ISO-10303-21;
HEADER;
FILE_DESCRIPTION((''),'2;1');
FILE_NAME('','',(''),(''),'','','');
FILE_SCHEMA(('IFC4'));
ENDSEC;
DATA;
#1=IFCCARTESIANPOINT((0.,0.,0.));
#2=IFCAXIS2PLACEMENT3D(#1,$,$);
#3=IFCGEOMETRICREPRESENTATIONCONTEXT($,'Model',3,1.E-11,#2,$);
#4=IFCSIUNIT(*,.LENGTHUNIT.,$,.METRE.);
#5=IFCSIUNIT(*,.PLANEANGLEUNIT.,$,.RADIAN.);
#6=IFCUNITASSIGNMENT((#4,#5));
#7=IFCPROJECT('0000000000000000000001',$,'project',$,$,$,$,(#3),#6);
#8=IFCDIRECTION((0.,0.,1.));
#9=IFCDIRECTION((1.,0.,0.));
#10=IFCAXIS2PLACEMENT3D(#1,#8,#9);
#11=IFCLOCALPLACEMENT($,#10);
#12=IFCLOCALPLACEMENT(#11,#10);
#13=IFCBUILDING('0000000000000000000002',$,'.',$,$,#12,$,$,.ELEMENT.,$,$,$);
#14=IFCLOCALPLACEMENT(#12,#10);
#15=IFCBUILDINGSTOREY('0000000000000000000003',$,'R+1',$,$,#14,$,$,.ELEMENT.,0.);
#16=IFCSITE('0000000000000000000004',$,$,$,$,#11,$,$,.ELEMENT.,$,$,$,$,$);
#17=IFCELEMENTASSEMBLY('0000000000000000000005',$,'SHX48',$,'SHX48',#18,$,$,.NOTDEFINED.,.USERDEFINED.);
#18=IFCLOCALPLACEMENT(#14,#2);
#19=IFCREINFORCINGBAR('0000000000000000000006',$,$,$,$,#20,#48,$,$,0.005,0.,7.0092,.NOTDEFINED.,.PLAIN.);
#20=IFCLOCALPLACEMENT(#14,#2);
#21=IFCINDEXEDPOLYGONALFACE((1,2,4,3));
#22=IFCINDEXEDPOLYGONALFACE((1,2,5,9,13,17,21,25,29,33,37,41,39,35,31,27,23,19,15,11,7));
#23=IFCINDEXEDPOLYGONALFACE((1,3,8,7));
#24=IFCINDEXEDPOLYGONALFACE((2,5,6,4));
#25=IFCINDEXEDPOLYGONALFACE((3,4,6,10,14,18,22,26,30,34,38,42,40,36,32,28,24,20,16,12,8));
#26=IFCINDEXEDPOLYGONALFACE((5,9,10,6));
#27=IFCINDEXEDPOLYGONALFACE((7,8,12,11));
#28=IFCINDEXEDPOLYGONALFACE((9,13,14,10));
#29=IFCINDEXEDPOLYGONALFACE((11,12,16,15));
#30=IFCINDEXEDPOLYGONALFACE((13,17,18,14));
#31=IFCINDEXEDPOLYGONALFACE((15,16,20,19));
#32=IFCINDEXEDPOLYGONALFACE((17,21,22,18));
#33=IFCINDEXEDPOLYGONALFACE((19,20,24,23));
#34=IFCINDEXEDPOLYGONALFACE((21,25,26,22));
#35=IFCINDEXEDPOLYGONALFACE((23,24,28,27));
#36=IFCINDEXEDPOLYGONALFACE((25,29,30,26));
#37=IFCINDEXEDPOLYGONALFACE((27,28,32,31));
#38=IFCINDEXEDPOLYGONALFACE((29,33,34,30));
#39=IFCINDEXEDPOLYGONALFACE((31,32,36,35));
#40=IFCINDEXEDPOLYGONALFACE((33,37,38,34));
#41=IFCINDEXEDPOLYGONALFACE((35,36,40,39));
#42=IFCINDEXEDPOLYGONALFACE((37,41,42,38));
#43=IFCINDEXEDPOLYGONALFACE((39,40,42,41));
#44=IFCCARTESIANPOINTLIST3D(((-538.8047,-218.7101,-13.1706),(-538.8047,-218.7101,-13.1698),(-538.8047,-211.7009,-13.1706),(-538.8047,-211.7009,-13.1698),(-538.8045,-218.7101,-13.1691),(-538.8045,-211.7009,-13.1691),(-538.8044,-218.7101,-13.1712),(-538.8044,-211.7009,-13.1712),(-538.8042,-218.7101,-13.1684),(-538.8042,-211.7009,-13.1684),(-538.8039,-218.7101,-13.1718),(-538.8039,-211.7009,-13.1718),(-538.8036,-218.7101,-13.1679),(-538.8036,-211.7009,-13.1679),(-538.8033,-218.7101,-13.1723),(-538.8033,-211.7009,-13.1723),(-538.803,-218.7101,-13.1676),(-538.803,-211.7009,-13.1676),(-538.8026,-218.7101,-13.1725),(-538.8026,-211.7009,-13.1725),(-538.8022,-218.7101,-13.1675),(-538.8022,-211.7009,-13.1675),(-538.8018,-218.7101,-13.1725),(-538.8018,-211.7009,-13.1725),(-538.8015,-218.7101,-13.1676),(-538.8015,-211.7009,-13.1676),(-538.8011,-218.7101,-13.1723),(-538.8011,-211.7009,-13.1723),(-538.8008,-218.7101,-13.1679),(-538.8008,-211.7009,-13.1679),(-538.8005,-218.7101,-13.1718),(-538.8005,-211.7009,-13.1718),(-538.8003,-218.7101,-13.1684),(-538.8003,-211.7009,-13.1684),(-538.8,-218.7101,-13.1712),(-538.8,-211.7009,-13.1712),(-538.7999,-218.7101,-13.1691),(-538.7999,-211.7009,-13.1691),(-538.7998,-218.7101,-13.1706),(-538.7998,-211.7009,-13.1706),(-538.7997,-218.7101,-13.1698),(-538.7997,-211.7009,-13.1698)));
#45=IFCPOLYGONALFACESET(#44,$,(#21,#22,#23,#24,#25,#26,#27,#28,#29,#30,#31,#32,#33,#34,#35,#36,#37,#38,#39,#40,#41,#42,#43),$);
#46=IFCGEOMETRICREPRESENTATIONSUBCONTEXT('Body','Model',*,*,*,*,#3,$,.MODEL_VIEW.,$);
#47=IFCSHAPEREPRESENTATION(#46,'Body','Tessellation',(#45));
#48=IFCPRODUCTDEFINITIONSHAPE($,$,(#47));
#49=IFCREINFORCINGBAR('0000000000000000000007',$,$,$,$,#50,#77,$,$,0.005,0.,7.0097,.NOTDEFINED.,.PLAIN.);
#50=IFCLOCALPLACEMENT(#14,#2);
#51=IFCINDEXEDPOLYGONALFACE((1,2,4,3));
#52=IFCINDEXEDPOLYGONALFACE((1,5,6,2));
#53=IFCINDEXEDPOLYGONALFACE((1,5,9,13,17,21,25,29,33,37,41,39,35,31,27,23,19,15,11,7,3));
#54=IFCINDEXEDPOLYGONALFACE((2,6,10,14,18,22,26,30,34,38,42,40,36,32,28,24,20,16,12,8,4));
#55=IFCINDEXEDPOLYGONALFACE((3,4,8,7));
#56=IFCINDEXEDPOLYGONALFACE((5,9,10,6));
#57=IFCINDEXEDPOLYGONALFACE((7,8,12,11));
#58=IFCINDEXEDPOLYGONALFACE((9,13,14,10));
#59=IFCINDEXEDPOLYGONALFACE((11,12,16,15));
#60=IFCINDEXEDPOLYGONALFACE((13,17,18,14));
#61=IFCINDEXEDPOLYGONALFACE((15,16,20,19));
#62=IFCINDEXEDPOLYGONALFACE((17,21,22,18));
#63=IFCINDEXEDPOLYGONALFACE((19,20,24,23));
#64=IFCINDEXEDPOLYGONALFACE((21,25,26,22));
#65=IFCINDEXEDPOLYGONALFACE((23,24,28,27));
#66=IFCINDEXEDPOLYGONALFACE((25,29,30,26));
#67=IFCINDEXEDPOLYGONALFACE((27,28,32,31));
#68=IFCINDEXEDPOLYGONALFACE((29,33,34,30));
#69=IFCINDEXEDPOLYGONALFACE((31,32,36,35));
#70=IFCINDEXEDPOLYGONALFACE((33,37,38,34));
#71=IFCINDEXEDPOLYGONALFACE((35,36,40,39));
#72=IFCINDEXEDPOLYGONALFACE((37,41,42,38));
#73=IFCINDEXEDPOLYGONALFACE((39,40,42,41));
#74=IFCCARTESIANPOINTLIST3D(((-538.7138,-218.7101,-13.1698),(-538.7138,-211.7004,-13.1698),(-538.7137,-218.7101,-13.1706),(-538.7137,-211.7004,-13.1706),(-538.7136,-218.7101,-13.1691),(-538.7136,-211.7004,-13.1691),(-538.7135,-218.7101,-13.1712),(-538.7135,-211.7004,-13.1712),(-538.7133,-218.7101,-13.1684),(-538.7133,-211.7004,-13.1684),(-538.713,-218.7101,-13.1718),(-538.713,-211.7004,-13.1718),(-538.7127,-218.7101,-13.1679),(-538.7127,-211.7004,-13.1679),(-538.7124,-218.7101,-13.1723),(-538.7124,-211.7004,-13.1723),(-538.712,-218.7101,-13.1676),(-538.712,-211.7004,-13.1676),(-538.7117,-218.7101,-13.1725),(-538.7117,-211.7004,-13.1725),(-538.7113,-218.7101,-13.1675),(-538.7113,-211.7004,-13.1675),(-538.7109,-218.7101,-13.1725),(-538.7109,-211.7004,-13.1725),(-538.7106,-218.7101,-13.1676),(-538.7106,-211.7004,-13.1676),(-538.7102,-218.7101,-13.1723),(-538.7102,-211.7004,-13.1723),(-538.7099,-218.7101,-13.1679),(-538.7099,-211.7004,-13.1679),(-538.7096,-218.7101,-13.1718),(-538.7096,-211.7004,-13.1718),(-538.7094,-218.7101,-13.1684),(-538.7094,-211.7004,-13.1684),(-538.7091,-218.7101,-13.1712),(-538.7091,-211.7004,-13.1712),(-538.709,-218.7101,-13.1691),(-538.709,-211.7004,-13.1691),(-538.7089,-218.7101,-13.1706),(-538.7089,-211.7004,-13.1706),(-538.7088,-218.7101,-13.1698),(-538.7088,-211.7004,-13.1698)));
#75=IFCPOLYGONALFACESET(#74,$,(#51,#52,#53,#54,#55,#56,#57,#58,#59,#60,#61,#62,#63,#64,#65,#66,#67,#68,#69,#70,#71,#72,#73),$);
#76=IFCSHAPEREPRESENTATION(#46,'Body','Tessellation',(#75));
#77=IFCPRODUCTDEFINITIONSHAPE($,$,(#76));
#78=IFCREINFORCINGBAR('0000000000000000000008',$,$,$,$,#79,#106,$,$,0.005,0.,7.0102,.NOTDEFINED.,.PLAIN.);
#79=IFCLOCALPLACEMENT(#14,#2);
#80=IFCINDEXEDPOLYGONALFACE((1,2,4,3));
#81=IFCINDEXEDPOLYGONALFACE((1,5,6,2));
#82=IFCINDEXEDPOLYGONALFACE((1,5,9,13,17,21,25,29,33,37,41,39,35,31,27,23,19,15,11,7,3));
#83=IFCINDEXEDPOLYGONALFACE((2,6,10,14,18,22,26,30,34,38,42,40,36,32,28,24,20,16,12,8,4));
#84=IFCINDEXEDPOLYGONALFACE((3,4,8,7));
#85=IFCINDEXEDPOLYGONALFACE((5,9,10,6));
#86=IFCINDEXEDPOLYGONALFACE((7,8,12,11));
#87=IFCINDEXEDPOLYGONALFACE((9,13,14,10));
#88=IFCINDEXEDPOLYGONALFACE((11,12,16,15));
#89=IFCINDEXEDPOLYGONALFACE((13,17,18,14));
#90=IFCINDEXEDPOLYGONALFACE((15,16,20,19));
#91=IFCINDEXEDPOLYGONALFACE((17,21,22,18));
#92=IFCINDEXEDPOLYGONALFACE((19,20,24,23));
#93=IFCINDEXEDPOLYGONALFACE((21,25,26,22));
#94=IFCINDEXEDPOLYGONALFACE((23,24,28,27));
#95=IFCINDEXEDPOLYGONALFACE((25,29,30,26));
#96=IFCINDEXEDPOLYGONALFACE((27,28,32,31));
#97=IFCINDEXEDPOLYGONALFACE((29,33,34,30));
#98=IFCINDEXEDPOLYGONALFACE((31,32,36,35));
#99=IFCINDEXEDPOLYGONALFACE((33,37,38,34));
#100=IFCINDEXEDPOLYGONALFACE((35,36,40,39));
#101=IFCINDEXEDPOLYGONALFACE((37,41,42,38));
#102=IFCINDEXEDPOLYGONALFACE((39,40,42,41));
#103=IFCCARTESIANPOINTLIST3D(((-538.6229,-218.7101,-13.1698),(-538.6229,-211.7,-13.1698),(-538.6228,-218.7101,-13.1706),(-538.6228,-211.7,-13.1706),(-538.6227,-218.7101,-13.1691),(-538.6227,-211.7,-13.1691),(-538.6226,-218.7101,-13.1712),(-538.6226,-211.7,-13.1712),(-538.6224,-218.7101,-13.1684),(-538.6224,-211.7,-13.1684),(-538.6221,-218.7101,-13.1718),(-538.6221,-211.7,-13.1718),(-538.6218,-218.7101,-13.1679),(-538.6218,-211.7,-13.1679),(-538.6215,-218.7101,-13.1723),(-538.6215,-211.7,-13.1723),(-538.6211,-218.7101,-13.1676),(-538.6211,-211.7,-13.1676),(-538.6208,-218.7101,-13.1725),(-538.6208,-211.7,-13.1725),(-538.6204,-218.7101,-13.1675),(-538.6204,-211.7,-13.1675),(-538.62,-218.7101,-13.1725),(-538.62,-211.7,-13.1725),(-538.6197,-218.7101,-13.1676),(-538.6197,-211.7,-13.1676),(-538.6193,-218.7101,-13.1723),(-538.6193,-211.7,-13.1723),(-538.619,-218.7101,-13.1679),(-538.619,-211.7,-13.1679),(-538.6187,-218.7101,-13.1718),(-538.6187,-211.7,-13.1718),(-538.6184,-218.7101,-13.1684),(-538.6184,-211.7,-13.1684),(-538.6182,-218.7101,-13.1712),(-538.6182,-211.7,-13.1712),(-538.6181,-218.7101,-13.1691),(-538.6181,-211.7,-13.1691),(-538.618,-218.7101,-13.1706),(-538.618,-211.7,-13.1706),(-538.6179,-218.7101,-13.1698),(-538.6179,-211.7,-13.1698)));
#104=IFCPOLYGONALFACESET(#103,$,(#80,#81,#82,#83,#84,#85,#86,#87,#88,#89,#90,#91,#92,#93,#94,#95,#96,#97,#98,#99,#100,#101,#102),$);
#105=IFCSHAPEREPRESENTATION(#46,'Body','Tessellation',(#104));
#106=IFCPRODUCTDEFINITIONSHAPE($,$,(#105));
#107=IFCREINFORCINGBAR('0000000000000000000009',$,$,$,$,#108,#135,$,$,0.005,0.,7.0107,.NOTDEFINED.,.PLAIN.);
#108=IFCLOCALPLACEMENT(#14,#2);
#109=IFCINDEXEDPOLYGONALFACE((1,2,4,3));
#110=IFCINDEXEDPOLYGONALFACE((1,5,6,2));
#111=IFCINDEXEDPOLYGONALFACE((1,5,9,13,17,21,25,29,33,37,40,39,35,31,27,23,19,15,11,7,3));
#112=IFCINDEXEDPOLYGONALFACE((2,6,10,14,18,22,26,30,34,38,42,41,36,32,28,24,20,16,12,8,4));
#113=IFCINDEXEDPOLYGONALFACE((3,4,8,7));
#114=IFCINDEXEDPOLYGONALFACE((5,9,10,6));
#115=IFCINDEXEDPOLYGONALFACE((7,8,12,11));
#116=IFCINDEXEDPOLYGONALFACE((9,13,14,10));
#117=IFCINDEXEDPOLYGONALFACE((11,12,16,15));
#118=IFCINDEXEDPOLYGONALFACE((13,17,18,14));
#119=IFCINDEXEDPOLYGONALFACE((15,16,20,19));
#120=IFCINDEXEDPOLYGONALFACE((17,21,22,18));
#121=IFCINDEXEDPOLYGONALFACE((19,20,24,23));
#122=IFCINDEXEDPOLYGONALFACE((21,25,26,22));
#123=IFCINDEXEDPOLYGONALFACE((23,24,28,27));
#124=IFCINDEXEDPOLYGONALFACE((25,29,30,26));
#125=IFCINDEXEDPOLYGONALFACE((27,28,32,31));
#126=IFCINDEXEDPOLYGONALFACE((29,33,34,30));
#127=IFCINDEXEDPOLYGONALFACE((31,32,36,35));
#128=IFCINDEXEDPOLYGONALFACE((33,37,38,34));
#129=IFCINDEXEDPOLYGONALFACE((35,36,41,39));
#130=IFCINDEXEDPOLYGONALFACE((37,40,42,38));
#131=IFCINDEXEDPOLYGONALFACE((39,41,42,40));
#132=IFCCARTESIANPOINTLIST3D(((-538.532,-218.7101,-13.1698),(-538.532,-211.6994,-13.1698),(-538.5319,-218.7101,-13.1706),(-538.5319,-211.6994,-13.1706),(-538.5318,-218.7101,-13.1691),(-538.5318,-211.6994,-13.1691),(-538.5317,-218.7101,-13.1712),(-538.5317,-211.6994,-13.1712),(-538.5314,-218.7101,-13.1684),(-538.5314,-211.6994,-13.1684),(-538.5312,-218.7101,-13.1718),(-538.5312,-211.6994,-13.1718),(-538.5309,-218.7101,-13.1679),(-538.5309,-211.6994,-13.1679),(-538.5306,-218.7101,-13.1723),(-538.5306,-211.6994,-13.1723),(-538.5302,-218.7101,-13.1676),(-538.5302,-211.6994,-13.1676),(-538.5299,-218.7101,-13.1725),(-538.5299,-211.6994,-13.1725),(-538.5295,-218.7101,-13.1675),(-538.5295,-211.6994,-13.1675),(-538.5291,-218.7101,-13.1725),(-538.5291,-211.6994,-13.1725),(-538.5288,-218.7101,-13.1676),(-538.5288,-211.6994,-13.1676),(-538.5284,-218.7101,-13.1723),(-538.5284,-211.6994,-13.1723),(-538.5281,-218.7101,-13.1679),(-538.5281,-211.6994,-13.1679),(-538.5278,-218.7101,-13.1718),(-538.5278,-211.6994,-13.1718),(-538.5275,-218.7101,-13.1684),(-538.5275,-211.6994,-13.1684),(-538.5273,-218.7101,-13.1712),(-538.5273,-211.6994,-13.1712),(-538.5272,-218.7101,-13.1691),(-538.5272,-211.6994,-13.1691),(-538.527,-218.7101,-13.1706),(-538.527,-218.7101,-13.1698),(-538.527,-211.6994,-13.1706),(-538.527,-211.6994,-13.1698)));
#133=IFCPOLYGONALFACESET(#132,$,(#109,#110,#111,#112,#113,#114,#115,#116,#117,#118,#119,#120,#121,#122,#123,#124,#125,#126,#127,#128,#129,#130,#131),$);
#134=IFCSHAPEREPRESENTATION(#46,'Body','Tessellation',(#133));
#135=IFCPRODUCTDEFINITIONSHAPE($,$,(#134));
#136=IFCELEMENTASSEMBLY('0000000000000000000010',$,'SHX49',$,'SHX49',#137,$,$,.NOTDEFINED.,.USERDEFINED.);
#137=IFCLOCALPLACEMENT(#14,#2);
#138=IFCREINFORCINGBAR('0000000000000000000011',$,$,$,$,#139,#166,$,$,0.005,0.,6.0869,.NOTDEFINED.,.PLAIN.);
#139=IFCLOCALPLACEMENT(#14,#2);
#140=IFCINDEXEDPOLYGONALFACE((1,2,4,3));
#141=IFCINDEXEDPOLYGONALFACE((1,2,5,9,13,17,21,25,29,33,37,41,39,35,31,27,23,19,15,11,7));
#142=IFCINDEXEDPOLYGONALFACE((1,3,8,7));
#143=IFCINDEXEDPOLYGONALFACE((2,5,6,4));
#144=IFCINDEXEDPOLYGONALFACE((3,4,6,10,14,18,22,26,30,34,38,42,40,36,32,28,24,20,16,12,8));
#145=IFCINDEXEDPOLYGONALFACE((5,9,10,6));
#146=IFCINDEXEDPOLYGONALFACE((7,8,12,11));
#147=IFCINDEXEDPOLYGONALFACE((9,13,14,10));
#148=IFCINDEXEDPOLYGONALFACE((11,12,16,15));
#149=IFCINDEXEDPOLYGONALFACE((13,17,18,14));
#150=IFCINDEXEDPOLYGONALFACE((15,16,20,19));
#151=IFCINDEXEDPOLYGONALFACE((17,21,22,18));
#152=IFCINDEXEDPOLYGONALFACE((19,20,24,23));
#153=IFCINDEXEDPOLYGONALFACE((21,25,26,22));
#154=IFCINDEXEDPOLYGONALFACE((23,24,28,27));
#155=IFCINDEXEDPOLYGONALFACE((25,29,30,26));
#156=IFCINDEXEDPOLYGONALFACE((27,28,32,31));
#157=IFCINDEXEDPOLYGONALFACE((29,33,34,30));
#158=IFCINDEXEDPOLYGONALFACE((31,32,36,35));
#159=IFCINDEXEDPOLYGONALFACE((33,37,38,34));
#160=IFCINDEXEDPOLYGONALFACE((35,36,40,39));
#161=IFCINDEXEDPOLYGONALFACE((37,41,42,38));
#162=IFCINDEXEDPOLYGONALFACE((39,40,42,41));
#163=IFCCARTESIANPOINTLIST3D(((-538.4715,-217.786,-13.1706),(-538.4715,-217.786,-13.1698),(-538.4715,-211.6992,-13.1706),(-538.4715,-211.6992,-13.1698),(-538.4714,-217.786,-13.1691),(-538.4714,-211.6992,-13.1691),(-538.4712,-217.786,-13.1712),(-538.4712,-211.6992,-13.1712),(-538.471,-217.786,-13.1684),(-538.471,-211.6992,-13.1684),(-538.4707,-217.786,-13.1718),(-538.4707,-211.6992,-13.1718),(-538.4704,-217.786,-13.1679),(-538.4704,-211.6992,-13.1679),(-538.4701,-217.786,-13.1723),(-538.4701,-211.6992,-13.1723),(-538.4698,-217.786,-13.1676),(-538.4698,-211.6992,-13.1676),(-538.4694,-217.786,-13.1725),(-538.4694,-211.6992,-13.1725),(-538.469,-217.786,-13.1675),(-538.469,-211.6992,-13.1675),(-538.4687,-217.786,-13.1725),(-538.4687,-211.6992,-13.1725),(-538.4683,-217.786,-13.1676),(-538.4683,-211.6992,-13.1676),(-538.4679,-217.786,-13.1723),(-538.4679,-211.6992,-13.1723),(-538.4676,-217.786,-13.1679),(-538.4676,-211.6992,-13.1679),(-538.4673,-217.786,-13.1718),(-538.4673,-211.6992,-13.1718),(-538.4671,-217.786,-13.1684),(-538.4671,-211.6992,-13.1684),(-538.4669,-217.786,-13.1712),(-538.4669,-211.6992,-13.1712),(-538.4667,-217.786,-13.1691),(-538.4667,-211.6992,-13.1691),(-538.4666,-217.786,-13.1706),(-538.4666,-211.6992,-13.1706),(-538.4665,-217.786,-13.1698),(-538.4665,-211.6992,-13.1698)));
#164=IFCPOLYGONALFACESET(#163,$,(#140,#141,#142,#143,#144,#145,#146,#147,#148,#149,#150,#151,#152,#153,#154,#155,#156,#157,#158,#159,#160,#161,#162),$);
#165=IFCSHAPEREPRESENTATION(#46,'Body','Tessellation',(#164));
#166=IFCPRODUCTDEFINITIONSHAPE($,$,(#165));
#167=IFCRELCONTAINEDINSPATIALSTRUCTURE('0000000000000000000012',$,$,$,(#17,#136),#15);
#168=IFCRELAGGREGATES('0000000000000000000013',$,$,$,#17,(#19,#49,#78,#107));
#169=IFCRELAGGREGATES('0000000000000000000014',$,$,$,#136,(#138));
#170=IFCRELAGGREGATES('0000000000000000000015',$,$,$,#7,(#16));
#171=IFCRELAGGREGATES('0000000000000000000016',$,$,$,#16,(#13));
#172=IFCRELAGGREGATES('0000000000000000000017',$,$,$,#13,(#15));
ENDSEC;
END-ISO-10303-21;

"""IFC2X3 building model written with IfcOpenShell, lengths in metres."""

from ifc_helpers import new_model, entity, si_unit, origin, origin_with_axes, place, context, subcontext, project, spatial, shape, element, aggregate, save


model = new_model("IFC2X3")

# Units and contexts
model_context = context("Model", 3, precision=1e-11, world=origin())
body_context = subcontext(model_context, "Body", "Model", "MODEL_VIEW")
ifc_project = project(units=[si_unit("LENGTHUNIT", "METRE"), si_unit("PLANEANGLEUNIT", "RADIAN")], contexts=[model_context])

# Site, building, storey
site_placement = place(None, origin_with_axes())
site = spatial("IfcSite", under=ifc_project, at=site_placement, CompositionType="ELEMENT")
building_placement = place(site_placement, origin_with_axes())
building = spatial("IfcBuilding", under=site, at=building_placement, Name=".", CompositionType="ELEMENT")
storey_placement = place(building_placement, origin_with_axes())
storey = spatial("IfcBuildingStorey", under=building, at=storey_placement, Name="R+1", CompositionType="ELEMENT", Elevation=0.0)

# Element assemblies, reinforcing bars
assembly_1_placement = place(storey_placement, origin_with_axes())
assembly_1 = element("IfcElementAssembly", 1, at=assembly_1_placement, inside=storey, Name="SHX48", ObjectType="SHX48", AssemblyPlace="NOTDEFINED", PredefinedType="USERDEFINED")
reinforcing_bar_1_placement = place(assembly_1_placement, origin_with_axes())
reinforcing_bar_1 = element("IfcReinforcingBar", 2, at=reinforcing_bar_1_placement, BarLength=7.0092, BarRole="NOTDEFINED", BarSurface="PLAIN", CrossSectionArea=0.0, NominalDiameter=0.005, shapes=[
    shape(body_context, "Body", "AdvancedSweptSolid", [entity("IfcSweptDiskSolid", entity("IfcPolyline", [entity("IfcCartesianPoint", [538.8022, 211.7009, 13.17]), entity("IfcCartesianPoint", [538.8022, 218.7101, 13.17])]), 0.0025, None, 0.0, 7.0092)]),
    shape(body_context, "Body", "AdvancedSweptSolid", [entity("IfcSweptDiskSolid", entity("IfcPolyline", [entity("IfcCartesianPoint", [538.8022, 211.7009, 13.17]), entity("IfcCartesianPoint", [538.8022, 218.7101, 13.17])]), 0.0025, None, 0.0, 7.0092)]),
])
reinforcing_bar_2_placement = place(assembly_1_placement, origin_with_axes())
reinforcing_bar_2 = element("IfcReinforcingBar", 3, at=reinforcing_bar_2_placement, BarLength=7.0097, BarRole="NOTDEFINED", BarSurface="PLAIN", CrossSectionArea=0.0, NominalDiameter=0.005, shapes=[
    shape(body_context, "Body", "AdvancedSweptSolid", [entity("IfcSweptDiskSolid", entity("IfcPolyline", [entity("IfcCartesianPoint", [538.7113, 211.7004, 13.17]), entity("IfcCartesianPoint", [538.7113, 218.7101, 13.17])]), 0.0025, None, 0.0, 7.0097)]),
    shape(body_context, "Body", "AdvancedSweptSolid", [entity("IfcSweptDiskSolid", entity("IfcPolyline", [entity("IfcCartesianPoint", [538.7113, 211.7004, 13.17]), entity("IfcCartesianPoint", [538.7113, 218.7101, 13.17])]), 0.0025, None, 0.0, 7.0097)]),
])
reinforcing_bar_3_placement = place(assembly_1_placement, origin_with_axes())
reinforcing_bar_3 = element("IfcReinforcingBar", 4, at=reinforcing_bar_3_placement, BarLength=7.0102, BarRole="NOTDEFINED", BarSurface="PLAIN", CrossSectionArea=0.0, NominalDiameter=0.005, shapes=[
    shape(body_context, "Body", "AdvancedSweptSolid", [entity("IfcSweptDiskSolid", entity("IfcPolyline", [entity("IfcCartesianPoint", [538.6204, 211.7, 13.17]), entity("IfcCartesianPoint", [538.6204, 218.7101, 13.17])]), 0.0025, None, 0.0, 7.0102)]),
    shape(body_context, "Body", "AdvancedSweptSolid", [entity("IfcSweptDiskSolid", entity("IfcPolyline", [entity("IfcCartesianPoint", [538.6204, 211.7, 13.17]), entity("IfcCartesianPoint", [538.6204, 218.7101, 13.17])]), 0.0025, None, 0.0, 7.0102)]),
])
reinforcing_bar_4_placement = place(assembly_1_placement, origin_with_axes())
reinforcing_bar_4 = element("IfcReinforcingBar", 5, at=reinforcing_bar_4_placement, BarLength=7.0107, BarRole="NOTDEFINED", BarSurface="PLAIN", CrossSectionArea=0.0, NominalDiameter=0.005, shapes=[
    shape(body_context, "Body", "AdvancedSweptSolid", [entity("IfcSweptDiskSolid", entity("IfcPolyline", [entity("IfcCartesianPoint", [538.5295, 211.6994, 13.17]), entity("IfcCartesianPoint", [538.5295, 218.7101, 13.17])]), 0.0025, None, 0.0, 7.0107)]),
    shape(body_context, "Body", "AdvancedSweptSolid", [entity("IfcSweptDiskSolid", entity("IfcPolyline", [entity("IfcCartesianPoint", [538.5295, 211.6994, 13.17]), entity("IfcCartesianPoint", [538.5295, 218.7101, 13.17])]), 0.0025, None, 0.0, 7.0107)]),
])
aggregate(assembly_1, [reinforcing_bar_1, reinforcing_bar_2, reinforcing_bar_3, reinforcing_bar_4])
assembly_2_placement = place(storey_placement, origin_with_axes())
assembly_2 = element("IfcElementAssembly", 6, at=assembly_2_placement, inside=storey, Name="SHX49", ObjectType="SHX49", AssemblyPlace="NOTDEFINED", PredefinedType="USERDEFINED")
reinforcing_bar_5_placement = place(assembly_2_placement, origin_with_axes())
reinforcing_bar_5 = element("IfcReinforcingBar", 7, at=reinforcing_bar_5_placement, BarLength=6.0869, BarRole="NOTDEFINED", BarSurface="PLAIN", CrossSectionArea=0.0, NominalDiameter=0.005, shapes=[
    shape(body_context, "Body", "AdvancedSweptSolid", [entity("IfcSweptDiskSolid", entity("IfcPolyline", [entity("IfcCartesianPoint", [538.469, 211.6992, 13.17]), entity("IfcCartesianPoint", [538.469, 217.786, 13.17])]), 0.0025, None, 0.0, 6.0869)]),
    shape(body_context, "Body", "AdvancedSweptSolid", [entity("IfcSweptDiskSolid", entity("IfcPolyline", [entity("IfcCartesianPoint", [538.469, 211.6992, 13.17]), entity("IfcCartesianPoint", [538.469, 217.786, 13.17])]), 0.0025, None, 0.0, 6.0869)]),
])
aggregate(assembly_2, [reinforcing_bar_5])

save(model, "model.ifc")
